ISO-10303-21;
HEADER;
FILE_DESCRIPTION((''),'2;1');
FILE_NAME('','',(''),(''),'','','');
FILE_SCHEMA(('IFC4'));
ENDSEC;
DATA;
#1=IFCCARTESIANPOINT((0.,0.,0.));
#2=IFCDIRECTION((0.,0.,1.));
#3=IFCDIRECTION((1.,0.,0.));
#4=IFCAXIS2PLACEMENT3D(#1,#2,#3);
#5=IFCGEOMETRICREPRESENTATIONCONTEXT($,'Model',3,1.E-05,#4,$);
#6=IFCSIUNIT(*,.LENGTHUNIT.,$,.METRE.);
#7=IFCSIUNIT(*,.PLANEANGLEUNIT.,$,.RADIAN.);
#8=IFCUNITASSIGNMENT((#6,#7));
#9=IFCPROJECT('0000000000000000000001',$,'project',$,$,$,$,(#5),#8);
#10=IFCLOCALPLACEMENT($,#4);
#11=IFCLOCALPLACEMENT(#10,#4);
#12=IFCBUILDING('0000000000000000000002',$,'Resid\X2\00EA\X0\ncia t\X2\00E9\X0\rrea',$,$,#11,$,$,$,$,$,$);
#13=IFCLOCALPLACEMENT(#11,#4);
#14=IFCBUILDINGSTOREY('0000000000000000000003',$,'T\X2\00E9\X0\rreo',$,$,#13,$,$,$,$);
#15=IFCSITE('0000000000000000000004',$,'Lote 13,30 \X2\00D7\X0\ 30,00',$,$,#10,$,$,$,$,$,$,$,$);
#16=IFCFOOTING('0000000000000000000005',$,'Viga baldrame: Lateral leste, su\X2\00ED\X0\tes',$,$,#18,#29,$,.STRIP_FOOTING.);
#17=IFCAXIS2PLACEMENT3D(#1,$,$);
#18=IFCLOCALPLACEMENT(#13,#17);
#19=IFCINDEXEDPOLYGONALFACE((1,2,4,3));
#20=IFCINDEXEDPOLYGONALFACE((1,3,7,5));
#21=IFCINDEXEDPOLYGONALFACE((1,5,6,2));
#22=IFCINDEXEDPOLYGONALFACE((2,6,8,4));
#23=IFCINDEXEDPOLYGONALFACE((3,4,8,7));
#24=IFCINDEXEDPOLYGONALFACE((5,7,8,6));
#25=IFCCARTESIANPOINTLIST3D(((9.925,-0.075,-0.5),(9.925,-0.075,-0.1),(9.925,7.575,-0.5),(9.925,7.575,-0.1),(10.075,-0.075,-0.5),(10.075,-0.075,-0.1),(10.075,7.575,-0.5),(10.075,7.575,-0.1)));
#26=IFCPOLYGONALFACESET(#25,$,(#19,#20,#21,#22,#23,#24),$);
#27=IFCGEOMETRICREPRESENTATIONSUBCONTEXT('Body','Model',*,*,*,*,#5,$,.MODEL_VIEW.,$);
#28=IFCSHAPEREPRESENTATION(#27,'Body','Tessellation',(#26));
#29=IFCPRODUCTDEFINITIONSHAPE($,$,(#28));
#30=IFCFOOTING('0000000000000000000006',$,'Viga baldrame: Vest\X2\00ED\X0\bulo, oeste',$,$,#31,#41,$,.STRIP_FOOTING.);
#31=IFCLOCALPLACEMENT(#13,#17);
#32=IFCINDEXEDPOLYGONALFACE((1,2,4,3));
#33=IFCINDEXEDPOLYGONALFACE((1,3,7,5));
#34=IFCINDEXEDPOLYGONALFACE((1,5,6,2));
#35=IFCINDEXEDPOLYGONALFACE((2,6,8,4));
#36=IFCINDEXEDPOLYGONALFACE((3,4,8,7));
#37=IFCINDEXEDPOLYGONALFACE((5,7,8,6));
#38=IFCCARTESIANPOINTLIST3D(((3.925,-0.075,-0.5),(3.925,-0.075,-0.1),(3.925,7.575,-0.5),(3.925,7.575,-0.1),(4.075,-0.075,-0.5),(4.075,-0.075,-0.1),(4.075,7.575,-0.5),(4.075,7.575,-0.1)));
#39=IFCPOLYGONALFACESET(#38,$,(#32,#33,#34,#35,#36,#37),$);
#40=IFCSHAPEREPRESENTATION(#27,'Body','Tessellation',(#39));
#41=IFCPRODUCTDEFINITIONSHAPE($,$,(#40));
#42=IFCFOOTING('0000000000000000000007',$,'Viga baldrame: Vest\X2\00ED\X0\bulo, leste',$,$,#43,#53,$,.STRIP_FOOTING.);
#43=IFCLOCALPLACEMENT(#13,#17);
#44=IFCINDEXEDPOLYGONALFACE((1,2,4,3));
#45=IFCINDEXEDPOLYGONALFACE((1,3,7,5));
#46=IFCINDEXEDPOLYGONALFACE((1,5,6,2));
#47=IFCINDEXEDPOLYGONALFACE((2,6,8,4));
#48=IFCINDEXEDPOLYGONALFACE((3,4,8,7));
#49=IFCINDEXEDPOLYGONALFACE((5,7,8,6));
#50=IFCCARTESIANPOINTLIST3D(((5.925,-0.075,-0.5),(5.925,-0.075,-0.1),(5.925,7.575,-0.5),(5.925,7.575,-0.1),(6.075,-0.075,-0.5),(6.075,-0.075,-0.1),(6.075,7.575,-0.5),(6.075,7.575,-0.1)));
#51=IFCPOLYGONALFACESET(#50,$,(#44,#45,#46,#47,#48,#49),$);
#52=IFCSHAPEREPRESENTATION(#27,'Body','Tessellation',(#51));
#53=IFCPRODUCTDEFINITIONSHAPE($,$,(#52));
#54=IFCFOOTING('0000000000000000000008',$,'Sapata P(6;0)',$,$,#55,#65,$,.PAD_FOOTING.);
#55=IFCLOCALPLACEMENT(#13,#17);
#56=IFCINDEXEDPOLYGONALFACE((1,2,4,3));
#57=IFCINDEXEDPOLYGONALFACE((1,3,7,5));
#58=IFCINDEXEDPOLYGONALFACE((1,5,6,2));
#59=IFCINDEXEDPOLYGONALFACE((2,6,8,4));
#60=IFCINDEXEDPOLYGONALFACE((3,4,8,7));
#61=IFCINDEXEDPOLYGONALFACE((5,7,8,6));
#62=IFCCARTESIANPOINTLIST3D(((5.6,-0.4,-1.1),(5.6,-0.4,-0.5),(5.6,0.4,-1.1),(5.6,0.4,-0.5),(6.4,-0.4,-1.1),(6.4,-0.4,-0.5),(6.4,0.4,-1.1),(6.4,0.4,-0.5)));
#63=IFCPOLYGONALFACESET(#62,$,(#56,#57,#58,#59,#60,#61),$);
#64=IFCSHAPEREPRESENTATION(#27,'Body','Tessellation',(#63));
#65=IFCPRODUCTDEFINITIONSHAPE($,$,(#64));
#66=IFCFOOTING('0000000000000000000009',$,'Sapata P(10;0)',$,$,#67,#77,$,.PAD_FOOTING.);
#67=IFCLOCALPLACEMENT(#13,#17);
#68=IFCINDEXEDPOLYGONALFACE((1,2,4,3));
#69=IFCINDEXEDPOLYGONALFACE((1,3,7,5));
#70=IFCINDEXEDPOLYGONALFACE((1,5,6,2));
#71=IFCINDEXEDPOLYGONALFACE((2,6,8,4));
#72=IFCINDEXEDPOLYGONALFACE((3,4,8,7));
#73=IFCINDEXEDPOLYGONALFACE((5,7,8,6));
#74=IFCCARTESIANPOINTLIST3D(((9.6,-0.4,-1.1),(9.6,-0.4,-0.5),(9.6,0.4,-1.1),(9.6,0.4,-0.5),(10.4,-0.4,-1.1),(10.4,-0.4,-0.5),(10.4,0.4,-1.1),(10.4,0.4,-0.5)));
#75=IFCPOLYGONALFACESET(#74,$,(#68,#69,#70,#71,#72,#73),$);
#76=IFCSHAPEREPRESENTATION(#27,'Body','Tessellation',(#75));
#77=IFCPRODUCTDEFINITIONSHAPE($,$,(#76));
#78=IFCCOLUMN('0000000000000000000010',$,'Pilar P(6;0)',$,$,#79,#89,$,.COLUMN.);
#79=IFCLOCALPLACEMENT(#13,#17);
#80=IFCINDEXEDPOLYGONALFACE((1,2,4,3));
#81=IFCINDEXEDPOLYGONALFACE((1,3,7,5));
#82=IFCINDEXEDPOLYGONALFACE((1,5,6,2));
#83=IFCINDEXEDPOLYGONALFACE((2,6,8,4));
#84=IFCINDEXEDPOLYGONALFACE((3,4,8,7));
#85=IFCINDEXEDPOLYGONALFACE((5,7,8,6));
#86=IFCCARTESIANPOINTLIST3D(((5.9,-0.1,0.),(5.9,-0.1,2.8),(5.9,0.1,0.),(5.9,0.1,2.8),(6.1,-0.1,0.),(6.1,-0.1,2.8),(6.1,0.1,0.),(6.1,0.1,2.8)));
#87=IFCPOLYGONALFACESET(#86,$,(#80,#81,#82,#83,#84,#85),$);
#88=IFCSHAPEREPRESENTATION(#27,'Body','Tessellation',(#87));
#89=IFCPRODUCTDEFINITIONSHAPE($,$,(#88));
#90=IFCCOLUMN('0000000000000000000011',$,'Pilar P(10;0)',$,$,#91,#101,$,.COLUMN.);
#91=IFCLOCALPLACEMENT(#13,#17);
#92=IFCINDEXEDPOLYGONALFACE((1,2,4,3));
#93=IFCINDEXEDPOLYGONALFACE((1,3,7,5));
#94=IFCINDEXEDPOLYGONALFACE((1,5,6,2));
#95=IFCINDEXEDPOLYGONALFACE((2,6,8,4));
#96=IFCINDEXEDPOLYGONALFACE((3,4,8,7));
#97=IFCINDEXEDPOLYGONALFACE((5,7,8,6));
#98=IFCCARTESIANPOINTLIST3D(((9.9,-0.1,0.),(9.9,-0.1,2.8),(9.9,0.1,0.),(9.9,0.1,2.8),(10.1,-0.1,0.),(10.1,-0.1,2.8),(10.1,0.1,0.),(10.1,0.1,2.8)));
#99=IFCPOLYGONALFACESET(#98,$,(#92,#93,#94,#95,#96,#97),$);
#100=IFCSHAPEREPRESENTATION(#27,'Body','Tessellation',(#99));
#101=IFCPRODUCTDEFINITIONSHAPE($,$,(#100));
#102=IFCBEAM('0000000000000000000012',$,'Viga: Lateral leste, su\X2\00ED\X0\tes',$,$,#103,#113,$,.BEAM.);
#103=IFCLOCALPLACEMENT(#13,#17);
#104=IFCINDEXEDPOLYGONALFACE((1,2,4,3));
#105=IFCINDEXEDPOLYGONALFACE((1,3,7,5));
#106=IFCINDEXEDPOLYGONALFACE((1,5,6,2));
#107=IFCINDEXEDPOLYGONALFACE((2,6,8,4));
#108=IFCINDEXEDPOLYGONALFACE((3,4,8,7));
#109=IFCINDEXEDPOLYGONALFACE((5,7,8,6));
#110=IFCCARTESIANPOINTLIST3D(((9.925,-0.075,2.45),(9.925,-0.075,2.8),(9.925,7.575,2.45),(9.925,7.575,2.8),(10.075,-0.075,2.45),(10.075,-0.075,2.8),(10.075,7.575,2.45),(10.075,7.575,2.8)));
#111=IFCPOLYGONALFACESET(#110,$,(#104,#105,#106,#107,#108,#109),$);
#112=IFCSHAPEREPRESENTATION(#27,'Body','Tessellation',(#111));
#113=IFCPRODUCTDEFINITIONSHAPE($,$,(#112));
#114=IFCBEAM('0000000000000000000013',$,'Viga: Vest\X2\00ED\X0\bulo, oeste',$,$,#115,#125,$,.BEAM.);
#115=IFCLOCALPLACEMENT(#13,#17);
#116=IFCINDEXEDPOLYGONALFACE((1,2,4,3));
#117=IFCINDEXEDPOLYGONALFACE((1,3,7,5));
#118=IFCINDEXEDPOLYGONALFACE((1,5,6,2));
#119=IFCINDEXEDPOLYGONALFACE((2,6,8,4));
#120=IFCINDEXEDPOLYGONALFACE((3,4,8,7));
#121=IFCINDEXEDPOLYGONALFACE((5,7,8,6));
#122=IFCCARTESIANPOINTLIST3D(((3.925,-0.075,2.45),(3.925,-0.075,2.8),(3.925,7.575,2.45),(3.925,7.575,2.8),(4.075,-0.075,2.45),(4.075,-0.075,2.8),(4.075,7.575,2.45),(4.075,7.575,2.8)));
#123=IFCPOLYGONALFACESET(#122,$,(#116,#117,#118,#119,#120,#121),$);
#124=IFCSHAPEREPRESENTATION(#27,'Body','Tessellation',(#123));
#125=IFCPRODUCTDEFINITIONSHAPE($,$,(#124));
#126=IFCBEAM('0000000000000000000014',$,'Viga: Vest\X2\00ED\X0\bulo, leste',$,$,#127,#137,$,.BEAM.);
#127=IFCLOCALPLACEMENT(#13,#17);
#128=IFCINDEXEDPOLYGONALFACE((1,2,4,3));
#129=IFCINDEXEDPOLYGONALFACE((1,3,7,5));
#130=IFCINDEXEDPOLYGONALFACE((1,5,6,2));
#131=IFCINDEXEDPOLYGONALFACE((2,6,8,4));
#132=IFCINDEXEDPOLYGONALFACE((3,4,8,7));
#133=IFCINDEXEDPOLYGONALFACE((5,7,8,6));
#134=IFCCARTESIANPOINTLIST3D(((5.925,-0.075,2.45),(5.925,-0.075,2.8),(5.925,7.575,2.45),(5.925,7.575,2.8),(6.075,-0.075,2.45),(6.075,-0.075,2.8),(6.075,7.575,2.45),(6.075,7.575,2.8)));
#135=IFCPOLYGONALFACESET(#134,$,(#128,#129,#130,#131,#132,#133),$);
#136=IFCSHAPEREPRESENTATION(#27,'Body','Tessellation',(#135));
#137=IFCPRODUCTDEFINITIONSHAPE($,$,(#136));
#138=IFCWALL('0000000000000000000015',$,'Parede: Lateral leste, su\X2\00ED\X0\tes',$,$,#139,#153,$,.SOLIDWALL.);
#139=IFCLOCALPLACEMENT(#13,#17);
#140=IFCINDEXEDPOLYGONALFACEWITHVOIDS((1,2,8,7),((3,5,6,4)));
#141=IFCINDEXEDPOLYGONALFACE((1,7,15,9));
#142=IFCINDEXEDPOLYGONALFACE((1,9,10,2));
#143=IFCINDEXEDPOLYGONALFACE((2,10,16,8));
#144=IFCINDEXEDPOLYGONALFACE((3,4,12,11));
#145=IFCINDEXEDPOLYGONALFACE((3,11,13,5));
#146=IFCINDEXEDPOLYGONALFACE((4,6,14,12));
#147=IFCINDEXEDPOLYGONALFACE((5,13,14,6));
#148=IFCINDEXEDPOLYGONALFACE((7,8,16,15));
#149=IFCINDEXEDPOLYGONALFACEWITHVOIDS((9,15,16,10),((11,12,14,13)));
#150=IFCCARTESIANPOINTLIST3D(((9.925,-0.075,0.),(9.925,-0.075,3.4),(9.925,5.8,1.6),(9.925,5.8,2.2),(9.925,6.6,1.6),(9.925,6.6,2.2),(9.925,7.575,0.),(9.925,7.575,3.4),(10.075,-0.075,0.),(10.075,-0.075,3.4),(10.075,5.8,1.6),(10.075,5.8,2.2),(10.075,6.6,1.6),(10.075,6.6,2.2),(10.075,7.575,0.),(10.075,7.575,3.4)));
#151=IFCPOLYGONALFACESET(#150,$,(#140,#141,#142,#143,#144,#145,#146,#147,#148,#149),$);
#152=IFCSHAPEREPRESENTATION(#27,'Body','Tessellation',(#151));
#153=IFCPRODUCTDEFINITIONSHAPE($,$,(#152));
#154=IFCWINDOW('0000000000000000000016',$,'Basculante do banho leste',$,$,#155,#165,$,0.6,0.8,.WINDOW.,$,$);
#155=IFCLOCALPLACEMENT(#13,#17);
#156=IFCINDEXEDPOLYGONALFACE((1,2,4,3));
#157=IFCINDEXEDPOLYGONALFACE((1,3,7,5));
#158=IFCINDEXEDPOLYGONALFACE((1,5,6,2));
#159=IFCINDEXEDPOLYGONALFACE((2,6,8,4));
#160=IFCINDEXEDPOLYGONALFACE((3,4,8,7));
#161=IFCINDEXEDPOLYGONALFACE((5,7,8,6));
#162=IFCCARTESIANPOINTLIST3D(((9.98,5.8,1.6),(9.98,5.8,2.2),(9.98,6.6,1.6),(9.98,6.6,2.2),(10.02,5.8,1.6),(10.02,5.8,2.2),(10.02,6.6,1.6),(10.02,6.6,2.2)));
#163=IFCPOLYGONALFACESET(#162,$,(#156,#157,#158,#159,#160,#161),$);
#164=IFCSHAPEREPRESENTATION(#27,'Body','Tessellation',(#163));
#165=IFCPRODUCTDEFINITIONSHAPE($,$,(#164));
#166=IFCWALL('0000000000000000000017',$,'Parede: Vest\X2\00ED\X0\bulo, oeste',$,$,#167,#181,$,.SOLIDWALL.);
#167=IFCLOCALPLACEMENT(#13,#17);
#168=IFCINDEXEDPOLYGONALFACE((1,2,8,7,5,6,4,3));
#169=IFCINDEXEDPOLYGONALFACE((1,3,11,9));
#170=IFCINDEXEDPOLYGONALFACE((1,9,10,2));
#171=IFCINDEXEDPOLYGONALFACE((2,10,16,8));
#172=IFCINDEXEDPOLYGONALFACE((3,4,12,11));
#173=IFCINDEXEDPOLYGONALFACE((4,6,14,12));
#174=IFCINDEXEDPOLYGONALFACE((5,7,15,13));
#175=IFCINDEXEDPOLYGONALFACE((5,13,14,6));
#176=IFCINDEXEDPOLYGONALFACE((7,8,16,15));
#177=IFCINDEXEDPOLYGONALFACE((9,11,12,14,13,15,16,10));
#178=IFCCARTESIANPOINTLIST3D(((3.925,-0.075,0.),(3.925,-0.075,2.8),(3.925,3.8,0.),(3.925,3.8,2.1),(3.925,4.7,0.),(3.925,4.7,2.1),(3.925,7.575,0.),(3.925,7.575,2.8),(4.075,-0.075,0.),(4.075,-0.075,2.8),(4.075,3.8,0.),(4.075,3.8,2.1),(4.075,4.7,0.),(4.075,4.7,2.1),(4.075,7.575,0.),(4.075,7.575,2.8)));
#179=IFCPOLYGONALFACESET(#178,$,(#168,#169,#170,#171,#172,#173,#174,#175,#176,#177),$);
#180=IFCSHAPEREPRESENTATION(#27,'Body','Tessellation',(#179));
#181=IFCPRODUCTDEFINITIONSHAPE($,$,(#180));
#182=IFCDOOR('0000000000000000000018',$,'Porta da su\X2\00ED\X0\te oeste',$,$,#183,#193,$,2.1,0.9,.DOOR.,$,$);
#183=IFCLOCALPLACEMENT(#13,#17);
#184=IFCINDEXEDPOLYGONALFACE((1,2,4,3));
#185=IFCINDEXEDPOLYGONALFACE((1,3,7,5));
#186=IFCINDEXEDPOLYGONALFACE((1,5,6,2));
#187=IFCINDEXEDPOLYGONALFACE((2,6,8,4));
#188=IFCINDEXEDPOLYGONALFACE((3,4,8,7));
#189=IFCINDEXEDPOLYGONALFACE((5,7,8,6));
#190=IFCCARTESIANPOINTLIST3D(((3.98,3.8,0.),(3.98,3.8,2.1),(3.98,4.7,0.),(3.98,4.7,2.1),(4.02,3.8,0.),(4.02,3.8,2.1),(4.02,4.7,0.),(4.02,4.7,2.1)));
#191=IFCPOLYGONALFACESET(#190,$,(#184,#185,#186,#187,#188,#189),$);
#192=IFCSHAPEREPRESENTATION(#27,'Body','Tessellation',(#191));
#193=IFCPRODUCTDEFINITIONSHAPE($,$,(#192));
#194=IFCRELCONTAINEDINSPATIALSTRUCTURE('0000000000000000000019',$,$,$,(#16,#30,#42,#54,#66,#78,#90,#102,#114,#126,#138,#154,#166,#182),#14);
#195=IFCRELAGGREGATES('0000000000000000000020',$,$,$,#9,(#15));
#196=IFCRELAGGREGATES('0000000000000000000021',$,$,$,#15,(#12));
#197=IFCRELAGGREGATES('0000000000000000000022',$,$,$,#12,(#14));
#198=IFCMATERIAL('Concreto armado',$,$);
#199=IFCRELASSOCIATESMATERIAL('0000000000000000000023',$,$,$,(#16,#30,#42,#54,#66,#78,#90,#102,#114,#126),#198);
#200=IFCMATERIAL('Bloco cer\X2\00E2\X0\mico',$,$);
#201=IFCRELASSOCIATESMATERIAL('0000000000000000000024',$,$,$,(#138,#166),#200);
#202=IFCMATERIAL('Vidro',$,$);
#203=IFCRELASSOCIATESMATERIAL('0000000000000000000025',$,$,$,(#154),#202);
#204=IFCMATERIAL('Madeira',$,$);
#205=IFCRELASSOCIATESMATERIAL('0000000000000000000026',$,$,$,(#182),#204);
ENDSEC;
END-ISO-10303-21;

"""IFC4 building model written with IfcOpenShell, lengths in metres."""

from ifc_helpers import new_model, si_unit, frame, origin_with_axes, place, context, subcontext, project, spatial, line, indexed_curve, outline, extrude, material, element, fill, save


model = new_model("IFC4")

# Units and contexts
model_context = context("Model", 3, precision=1e-05, world=origin_with_axes())
body_context = subcontext(model_context, "Body", "Model", "MODEL_VIEW")
ifc_project = project(units=[si_unit("LENGTHUNIT", "METRE"), si_unit("PLANEANGLEUNIT", "RADIAN")], contexts=[model_context])

# Site, building, storey
site_placement = place(None, origin_with_axes())
site = spatial("IfcSite", under=ifc_project, at=site_placement, Name="Lote 13,30 × 30,00")
building_placement = place(site_placement, origin_with_axes())
building = spatial("IfcBuilding", under=site, at=building_placement, Name="Residência térrea")
storey_placement = place(building_placement, origin_with_axes())
storey = spatial("IfcBuildingStorey", under=building, at=storey_placement, Name="Térreo")

# Footings
ifc_material_1 = material(Name="Concreto armado")
footing_placement = place(storey_placement, frame((9.925, -0.075, -0.5), z_axis=(0.0, 0.0, 1.0), x_axis=(1.0, 0.0, 0.0)))
element("IfcFooting", 1, at=footing_placement, inside=storey, material=ifc_material_1, Name="Viga baldrame: Lateral leste, suítes", PredefinedType="STRIP_FOOTING", context=body_context, shape_type="SweptSolid", body=[
    extrude(outline(indexed_curve([(0.0, 0.0), (0.15, 0.0), (0.15, 7.65), (0.0, 7.65)], segments=[line(1, 2, 3, 4, 1)])), origin_with_axes(), (0.0, 0.0, 1.0), 0.4),
])
for number, where, z_axis, x_axis, name in (
    (2, (3.925, -0.075, -0.5), (0.0, 0.0, 1.0), (1.0, 0.0, 0.0), "Viga baldrame: Vestíbulo, oeste"),
    (3, (5.925, -0.075, -0.5), (0.0, 0.0, 1.0), (1.0, 0.0, 0.0), "Viga baldrame: Vestíbulo, leste"),
):
    element("IfcFooting", number, at=place(storey_placement, frame(where, z_axis=z_axis, x_axis=x_axis)), inside=storey, material=ifc_material_1, Name=name, PredefinedType="STRIP_FOOTING", context=body_context, shape_type="SweptSolid", body=[
        extrude(outline(indexed_curve([(0.0, 0.0), (0.15, 0.0), (0.15, 7.65), (0.0, 7.65)], segments=[line(1, 2, 3, 4, 1)])), origin_with_axes(), (0.0, 0.0, 1.0), 0.4),
    ])
for number, where, z_axis, x_axis, name in (
    (4, (5.6, -0.4, -1.1), (0.0, 0.0, 1.0), (1.0, 0.0, 0.0), "Sapata P(6;0)"),
    (5, (9.6, -0.4, -1.1), (0.0, 0.0, 1.0), (1.0, 0.0, 0.0), "Sapata P(10;0)"),
):
    element("IfcFooting", number, at=place(storey_placement, frame(where, z_axis=z_axis, x_axis=x_axis)), inside=storey, material=ifc_material_1, Name=name, PredefinedType="PAD_FOOTING", context=body_context, shape_type="SweptSolid", body=[
        extrude(outline(indexed_curve([(0.0, 0.0), (0.8, 0.0), (0.8, 0.8), (0.0, 0.8)], segments=[line(1, 2, 3, 4, 1)])), origin_with_axes(), (0.0, 0.0, 1.0), 0.6),
    ])

# Columns
for number, where, z_axis, x_axis, name in (
    (6, (5.9, -0.1, 0.0), (0.0, 0.0, 1.0), (1.0, 0.0, 0.0), "Pilar P(6;0)"),
    (7, (9.9, -0.1, 0.0), (0.0, 0.0, 1.0), (1.0, 0.0, 0.0), "Pilar P(10;0)"),
):
    element("IfcColumn", number, at=place(storey_placement, frame(where, z_axis=z_axis, x_axis=x_axis)), inside=storey, material=ifc_material_1, Name=name, PredefinedType="COLUMN", context=body_context, shape_type="SweptSolid", body=[
        extrude(outline(indexed_curve([(0.0, 0.0), (0.2, 0.0), (0.2, 0.2), (0.0, 0.2)], segments=[line(1, 2, 3, 4, 1)])), origin_with_axes(), (0.0, 0.0, 1.0), 2.8),
    ])

# Beams
beam_placement = place(storey_placement, frame((9.925, -0.075, 2.45), z_axis=(0.0, 0.0, 1.0), x_axis=(1.0, 0.0, 0.0)))
element("IfcBeam", 8, at=beam_placement, inside=storey, material=ifc_material_1, Name="Viga: Lateral leste, suítes", PredefinedType="BEAM", context=body_context, shape_type="SweptSolid", body=[
    extrude(outline(indexed_curve([(0.0, 0.0), (0.15, 0.0), (0.15, 7.65), (0.0, 7.65)], segments=[line(1, 2, 3, 4, 1)])), origin_with_axes(), (0.0, 0.0, 1.0), 0.35),
])
for number, where, z_axis, x_axis, name in (
    (9, (3.925, -0.075, 2.45), (0.0, 0.0, 1.0), (1.0, 0.0, 0.0), "Viga: Vestíbulo, oeste"),
    (10, (5.925, -0.075, 2.45), (0.0, 0.0, 1.0), (1.0, 0.0, 0.0), "Viga: Vestíbulo, leste"),
):
    element("IfcBeam", number, at=place(storey_placement, frame(where, z_axis=z_axis, x_axis=x_axis)), inside=storey, material=ifc_material_1, Name=name, PredefinedType="BEAM", context=body_context, shape_type="SweptSolid", body=[
        extrude(outline(indexed_curve([(0.0, 0.0), (0.15, 0.0), (0.15, 7.65), (0.0, 7.65)], segments=[line(1, 2, 3, 4, 1)])), origin_with_axes(), (0.0, 0.0, 1.0), 0.35),
    ])

# Wall, opening, window
ifc_material_2 = material(Name="Bloco cerâmico")
wall_1_placement = place(storey_placement, frame((9.925, -0.075, 0.0), z_axis=(0.0, 0.0, 1.0), x_axis=(1.0, 0.0, 0.0)))
wall_1 = element("IfcWall", 11, at=wall_1_placement, inside=storey, material=ifc_material_2, Name="Parede: Lateral leste, suítes", PredefinedType="SOLIDWALL", context=body_context, shape_type="SweptSolid", body=[
    extrude(outline(indexed_curve([(0.0, 0.0), (0.15, 0.0), (0.15, 7.65), (0.0, 7.65)], segments=[line(1, 2, 3, 4, 1)])), origin_with_axes(), (0.0, 0.0, 1.0), 3.4),
])
opening_1_placement = place(wall_1_placement, frame((-0.05, 5.875, 1.6), z_axis=(0.0, 0.0, 1.0), x_axis=(1.0, 0.0, 0.0)))
opening_1 = element("IfcOpeningElement", 12, at=opening_1_placement, cuts=wall_1, material=ifc_material_1, PredefinedType="OPENING", context=body_context, shape_type="SweptSolid", body=[
    extrude(outline(indexed_curve([(0.0, 0.0), (0.25, 0.0), (0.25, 0.8), (0.0, 0.8)], segments=[line(1, 2, 3, 4, 1)])), origin_with_axes(), (0.0, 0.0, 1.0), 0.6),
])
ifc_material_3 = material(Name="Vidro")
window_placement = place(storey_placement, frame((9.98, 5.8, 1.6), z_axis=(0.0, 0.0, 1.0), x_axis=(1.0, 0.0, 0.0)))
window = element("IfcWindow", 13, at=window_placement, inside=storey, material=ifc_material_3, Name="Basculante do banho leste", OverallHeight=0.6, OverallWidth=0.8, PredefinedType="WINDOW", context=body_context, shape_type="SweptSolid", body=[
    extrude(outline(indexed_curve([(0.0, 0.0), (0.04, 0.0), (0.04, 0.8), (0.0, 0.8)], segments=[line(1, 2, 3, 4, 1)])), origin_with_axes(), (0.0, 0.0, 1.0), 0.6),
])
fill(opening_1, window)

# Wall, opening, door
wall_2_placement = place(storey_placement, frame((3.925, -0.075, 0.0), z_axis=(0.0, 0.0, 1.0), x_axis=(1.0, 0.0, 0.0)))
wall_2 = element("IfcWall", 14, at=wall_2_placement, inside=storey, material=ifc_material_2, Name="Parede: Vestíbulo, oeste", PredefinedType="SOLIDWALL", context=body_context, shape_type="SweptSolid", body=[
    extrude(outline(indexed_curve([(0.0, 0.0), (0.15, 0.0), (0.15, 7.65), (0.0, 7.65)], segments=[line(1, 2, 3, 4, 1)])), origin_with_axes(), (0.0, 0.0, 1.0), 2.8),
])
opening_2_placement = place(wall_2_placement, frame((-0.05, 3.875, 0.0), z_axis=(0.0, 0.0, 1.0), x_axis=(1.0, 0.0, 0.0)))
opening_2 = element("IfcOpeningElement", 15, at=opening_2_placement, cuts=wall_2, material=ifc_material_1, PredefinedType="OPENING", context=body_context, shape_type="SweptSolid", body=[
    extrude(outline(indexed_curve([(0.0, 0.0), (0.25, 0.0), (0.25, 0.9), (0.0, 0.9)], segments=[line(1, 2, 3, 4, 1)])), origin_with_axes(), (0.0, 0.0, 1.0), 2.1),
])
ifc_material_4 = material(Name="Madeira")
door_1_placement = place(storey_placement, frame((3.98, 3.8, 0.0), z_axis=(0.0, 0.0, 1.0), x_axis=(1.0, 0.0, 0.0)))
door_1 = element("IfcDoor", 16, at=door_1_placement, inside=storey, material=ifc_material_4, Name="Porta da suíte oeste", OverallHeight=2.1, OverallWidth=0.9, PredefinedType="DOOR", context=body_context, shape_type="SweptSolid", body=[
    extrude(outline(indexed_curve([(0.0, 0.0), (0.04, 0.0), (0.04, 0.9), (0.0, 0.9)], segments=[line(1, 2, 3, 4, 1)])), origin_with_axes(), (0.0, 0.0, 1.0), 2.1),
])
fill(opening_2, door_1)

save(model, "model.ifc")
